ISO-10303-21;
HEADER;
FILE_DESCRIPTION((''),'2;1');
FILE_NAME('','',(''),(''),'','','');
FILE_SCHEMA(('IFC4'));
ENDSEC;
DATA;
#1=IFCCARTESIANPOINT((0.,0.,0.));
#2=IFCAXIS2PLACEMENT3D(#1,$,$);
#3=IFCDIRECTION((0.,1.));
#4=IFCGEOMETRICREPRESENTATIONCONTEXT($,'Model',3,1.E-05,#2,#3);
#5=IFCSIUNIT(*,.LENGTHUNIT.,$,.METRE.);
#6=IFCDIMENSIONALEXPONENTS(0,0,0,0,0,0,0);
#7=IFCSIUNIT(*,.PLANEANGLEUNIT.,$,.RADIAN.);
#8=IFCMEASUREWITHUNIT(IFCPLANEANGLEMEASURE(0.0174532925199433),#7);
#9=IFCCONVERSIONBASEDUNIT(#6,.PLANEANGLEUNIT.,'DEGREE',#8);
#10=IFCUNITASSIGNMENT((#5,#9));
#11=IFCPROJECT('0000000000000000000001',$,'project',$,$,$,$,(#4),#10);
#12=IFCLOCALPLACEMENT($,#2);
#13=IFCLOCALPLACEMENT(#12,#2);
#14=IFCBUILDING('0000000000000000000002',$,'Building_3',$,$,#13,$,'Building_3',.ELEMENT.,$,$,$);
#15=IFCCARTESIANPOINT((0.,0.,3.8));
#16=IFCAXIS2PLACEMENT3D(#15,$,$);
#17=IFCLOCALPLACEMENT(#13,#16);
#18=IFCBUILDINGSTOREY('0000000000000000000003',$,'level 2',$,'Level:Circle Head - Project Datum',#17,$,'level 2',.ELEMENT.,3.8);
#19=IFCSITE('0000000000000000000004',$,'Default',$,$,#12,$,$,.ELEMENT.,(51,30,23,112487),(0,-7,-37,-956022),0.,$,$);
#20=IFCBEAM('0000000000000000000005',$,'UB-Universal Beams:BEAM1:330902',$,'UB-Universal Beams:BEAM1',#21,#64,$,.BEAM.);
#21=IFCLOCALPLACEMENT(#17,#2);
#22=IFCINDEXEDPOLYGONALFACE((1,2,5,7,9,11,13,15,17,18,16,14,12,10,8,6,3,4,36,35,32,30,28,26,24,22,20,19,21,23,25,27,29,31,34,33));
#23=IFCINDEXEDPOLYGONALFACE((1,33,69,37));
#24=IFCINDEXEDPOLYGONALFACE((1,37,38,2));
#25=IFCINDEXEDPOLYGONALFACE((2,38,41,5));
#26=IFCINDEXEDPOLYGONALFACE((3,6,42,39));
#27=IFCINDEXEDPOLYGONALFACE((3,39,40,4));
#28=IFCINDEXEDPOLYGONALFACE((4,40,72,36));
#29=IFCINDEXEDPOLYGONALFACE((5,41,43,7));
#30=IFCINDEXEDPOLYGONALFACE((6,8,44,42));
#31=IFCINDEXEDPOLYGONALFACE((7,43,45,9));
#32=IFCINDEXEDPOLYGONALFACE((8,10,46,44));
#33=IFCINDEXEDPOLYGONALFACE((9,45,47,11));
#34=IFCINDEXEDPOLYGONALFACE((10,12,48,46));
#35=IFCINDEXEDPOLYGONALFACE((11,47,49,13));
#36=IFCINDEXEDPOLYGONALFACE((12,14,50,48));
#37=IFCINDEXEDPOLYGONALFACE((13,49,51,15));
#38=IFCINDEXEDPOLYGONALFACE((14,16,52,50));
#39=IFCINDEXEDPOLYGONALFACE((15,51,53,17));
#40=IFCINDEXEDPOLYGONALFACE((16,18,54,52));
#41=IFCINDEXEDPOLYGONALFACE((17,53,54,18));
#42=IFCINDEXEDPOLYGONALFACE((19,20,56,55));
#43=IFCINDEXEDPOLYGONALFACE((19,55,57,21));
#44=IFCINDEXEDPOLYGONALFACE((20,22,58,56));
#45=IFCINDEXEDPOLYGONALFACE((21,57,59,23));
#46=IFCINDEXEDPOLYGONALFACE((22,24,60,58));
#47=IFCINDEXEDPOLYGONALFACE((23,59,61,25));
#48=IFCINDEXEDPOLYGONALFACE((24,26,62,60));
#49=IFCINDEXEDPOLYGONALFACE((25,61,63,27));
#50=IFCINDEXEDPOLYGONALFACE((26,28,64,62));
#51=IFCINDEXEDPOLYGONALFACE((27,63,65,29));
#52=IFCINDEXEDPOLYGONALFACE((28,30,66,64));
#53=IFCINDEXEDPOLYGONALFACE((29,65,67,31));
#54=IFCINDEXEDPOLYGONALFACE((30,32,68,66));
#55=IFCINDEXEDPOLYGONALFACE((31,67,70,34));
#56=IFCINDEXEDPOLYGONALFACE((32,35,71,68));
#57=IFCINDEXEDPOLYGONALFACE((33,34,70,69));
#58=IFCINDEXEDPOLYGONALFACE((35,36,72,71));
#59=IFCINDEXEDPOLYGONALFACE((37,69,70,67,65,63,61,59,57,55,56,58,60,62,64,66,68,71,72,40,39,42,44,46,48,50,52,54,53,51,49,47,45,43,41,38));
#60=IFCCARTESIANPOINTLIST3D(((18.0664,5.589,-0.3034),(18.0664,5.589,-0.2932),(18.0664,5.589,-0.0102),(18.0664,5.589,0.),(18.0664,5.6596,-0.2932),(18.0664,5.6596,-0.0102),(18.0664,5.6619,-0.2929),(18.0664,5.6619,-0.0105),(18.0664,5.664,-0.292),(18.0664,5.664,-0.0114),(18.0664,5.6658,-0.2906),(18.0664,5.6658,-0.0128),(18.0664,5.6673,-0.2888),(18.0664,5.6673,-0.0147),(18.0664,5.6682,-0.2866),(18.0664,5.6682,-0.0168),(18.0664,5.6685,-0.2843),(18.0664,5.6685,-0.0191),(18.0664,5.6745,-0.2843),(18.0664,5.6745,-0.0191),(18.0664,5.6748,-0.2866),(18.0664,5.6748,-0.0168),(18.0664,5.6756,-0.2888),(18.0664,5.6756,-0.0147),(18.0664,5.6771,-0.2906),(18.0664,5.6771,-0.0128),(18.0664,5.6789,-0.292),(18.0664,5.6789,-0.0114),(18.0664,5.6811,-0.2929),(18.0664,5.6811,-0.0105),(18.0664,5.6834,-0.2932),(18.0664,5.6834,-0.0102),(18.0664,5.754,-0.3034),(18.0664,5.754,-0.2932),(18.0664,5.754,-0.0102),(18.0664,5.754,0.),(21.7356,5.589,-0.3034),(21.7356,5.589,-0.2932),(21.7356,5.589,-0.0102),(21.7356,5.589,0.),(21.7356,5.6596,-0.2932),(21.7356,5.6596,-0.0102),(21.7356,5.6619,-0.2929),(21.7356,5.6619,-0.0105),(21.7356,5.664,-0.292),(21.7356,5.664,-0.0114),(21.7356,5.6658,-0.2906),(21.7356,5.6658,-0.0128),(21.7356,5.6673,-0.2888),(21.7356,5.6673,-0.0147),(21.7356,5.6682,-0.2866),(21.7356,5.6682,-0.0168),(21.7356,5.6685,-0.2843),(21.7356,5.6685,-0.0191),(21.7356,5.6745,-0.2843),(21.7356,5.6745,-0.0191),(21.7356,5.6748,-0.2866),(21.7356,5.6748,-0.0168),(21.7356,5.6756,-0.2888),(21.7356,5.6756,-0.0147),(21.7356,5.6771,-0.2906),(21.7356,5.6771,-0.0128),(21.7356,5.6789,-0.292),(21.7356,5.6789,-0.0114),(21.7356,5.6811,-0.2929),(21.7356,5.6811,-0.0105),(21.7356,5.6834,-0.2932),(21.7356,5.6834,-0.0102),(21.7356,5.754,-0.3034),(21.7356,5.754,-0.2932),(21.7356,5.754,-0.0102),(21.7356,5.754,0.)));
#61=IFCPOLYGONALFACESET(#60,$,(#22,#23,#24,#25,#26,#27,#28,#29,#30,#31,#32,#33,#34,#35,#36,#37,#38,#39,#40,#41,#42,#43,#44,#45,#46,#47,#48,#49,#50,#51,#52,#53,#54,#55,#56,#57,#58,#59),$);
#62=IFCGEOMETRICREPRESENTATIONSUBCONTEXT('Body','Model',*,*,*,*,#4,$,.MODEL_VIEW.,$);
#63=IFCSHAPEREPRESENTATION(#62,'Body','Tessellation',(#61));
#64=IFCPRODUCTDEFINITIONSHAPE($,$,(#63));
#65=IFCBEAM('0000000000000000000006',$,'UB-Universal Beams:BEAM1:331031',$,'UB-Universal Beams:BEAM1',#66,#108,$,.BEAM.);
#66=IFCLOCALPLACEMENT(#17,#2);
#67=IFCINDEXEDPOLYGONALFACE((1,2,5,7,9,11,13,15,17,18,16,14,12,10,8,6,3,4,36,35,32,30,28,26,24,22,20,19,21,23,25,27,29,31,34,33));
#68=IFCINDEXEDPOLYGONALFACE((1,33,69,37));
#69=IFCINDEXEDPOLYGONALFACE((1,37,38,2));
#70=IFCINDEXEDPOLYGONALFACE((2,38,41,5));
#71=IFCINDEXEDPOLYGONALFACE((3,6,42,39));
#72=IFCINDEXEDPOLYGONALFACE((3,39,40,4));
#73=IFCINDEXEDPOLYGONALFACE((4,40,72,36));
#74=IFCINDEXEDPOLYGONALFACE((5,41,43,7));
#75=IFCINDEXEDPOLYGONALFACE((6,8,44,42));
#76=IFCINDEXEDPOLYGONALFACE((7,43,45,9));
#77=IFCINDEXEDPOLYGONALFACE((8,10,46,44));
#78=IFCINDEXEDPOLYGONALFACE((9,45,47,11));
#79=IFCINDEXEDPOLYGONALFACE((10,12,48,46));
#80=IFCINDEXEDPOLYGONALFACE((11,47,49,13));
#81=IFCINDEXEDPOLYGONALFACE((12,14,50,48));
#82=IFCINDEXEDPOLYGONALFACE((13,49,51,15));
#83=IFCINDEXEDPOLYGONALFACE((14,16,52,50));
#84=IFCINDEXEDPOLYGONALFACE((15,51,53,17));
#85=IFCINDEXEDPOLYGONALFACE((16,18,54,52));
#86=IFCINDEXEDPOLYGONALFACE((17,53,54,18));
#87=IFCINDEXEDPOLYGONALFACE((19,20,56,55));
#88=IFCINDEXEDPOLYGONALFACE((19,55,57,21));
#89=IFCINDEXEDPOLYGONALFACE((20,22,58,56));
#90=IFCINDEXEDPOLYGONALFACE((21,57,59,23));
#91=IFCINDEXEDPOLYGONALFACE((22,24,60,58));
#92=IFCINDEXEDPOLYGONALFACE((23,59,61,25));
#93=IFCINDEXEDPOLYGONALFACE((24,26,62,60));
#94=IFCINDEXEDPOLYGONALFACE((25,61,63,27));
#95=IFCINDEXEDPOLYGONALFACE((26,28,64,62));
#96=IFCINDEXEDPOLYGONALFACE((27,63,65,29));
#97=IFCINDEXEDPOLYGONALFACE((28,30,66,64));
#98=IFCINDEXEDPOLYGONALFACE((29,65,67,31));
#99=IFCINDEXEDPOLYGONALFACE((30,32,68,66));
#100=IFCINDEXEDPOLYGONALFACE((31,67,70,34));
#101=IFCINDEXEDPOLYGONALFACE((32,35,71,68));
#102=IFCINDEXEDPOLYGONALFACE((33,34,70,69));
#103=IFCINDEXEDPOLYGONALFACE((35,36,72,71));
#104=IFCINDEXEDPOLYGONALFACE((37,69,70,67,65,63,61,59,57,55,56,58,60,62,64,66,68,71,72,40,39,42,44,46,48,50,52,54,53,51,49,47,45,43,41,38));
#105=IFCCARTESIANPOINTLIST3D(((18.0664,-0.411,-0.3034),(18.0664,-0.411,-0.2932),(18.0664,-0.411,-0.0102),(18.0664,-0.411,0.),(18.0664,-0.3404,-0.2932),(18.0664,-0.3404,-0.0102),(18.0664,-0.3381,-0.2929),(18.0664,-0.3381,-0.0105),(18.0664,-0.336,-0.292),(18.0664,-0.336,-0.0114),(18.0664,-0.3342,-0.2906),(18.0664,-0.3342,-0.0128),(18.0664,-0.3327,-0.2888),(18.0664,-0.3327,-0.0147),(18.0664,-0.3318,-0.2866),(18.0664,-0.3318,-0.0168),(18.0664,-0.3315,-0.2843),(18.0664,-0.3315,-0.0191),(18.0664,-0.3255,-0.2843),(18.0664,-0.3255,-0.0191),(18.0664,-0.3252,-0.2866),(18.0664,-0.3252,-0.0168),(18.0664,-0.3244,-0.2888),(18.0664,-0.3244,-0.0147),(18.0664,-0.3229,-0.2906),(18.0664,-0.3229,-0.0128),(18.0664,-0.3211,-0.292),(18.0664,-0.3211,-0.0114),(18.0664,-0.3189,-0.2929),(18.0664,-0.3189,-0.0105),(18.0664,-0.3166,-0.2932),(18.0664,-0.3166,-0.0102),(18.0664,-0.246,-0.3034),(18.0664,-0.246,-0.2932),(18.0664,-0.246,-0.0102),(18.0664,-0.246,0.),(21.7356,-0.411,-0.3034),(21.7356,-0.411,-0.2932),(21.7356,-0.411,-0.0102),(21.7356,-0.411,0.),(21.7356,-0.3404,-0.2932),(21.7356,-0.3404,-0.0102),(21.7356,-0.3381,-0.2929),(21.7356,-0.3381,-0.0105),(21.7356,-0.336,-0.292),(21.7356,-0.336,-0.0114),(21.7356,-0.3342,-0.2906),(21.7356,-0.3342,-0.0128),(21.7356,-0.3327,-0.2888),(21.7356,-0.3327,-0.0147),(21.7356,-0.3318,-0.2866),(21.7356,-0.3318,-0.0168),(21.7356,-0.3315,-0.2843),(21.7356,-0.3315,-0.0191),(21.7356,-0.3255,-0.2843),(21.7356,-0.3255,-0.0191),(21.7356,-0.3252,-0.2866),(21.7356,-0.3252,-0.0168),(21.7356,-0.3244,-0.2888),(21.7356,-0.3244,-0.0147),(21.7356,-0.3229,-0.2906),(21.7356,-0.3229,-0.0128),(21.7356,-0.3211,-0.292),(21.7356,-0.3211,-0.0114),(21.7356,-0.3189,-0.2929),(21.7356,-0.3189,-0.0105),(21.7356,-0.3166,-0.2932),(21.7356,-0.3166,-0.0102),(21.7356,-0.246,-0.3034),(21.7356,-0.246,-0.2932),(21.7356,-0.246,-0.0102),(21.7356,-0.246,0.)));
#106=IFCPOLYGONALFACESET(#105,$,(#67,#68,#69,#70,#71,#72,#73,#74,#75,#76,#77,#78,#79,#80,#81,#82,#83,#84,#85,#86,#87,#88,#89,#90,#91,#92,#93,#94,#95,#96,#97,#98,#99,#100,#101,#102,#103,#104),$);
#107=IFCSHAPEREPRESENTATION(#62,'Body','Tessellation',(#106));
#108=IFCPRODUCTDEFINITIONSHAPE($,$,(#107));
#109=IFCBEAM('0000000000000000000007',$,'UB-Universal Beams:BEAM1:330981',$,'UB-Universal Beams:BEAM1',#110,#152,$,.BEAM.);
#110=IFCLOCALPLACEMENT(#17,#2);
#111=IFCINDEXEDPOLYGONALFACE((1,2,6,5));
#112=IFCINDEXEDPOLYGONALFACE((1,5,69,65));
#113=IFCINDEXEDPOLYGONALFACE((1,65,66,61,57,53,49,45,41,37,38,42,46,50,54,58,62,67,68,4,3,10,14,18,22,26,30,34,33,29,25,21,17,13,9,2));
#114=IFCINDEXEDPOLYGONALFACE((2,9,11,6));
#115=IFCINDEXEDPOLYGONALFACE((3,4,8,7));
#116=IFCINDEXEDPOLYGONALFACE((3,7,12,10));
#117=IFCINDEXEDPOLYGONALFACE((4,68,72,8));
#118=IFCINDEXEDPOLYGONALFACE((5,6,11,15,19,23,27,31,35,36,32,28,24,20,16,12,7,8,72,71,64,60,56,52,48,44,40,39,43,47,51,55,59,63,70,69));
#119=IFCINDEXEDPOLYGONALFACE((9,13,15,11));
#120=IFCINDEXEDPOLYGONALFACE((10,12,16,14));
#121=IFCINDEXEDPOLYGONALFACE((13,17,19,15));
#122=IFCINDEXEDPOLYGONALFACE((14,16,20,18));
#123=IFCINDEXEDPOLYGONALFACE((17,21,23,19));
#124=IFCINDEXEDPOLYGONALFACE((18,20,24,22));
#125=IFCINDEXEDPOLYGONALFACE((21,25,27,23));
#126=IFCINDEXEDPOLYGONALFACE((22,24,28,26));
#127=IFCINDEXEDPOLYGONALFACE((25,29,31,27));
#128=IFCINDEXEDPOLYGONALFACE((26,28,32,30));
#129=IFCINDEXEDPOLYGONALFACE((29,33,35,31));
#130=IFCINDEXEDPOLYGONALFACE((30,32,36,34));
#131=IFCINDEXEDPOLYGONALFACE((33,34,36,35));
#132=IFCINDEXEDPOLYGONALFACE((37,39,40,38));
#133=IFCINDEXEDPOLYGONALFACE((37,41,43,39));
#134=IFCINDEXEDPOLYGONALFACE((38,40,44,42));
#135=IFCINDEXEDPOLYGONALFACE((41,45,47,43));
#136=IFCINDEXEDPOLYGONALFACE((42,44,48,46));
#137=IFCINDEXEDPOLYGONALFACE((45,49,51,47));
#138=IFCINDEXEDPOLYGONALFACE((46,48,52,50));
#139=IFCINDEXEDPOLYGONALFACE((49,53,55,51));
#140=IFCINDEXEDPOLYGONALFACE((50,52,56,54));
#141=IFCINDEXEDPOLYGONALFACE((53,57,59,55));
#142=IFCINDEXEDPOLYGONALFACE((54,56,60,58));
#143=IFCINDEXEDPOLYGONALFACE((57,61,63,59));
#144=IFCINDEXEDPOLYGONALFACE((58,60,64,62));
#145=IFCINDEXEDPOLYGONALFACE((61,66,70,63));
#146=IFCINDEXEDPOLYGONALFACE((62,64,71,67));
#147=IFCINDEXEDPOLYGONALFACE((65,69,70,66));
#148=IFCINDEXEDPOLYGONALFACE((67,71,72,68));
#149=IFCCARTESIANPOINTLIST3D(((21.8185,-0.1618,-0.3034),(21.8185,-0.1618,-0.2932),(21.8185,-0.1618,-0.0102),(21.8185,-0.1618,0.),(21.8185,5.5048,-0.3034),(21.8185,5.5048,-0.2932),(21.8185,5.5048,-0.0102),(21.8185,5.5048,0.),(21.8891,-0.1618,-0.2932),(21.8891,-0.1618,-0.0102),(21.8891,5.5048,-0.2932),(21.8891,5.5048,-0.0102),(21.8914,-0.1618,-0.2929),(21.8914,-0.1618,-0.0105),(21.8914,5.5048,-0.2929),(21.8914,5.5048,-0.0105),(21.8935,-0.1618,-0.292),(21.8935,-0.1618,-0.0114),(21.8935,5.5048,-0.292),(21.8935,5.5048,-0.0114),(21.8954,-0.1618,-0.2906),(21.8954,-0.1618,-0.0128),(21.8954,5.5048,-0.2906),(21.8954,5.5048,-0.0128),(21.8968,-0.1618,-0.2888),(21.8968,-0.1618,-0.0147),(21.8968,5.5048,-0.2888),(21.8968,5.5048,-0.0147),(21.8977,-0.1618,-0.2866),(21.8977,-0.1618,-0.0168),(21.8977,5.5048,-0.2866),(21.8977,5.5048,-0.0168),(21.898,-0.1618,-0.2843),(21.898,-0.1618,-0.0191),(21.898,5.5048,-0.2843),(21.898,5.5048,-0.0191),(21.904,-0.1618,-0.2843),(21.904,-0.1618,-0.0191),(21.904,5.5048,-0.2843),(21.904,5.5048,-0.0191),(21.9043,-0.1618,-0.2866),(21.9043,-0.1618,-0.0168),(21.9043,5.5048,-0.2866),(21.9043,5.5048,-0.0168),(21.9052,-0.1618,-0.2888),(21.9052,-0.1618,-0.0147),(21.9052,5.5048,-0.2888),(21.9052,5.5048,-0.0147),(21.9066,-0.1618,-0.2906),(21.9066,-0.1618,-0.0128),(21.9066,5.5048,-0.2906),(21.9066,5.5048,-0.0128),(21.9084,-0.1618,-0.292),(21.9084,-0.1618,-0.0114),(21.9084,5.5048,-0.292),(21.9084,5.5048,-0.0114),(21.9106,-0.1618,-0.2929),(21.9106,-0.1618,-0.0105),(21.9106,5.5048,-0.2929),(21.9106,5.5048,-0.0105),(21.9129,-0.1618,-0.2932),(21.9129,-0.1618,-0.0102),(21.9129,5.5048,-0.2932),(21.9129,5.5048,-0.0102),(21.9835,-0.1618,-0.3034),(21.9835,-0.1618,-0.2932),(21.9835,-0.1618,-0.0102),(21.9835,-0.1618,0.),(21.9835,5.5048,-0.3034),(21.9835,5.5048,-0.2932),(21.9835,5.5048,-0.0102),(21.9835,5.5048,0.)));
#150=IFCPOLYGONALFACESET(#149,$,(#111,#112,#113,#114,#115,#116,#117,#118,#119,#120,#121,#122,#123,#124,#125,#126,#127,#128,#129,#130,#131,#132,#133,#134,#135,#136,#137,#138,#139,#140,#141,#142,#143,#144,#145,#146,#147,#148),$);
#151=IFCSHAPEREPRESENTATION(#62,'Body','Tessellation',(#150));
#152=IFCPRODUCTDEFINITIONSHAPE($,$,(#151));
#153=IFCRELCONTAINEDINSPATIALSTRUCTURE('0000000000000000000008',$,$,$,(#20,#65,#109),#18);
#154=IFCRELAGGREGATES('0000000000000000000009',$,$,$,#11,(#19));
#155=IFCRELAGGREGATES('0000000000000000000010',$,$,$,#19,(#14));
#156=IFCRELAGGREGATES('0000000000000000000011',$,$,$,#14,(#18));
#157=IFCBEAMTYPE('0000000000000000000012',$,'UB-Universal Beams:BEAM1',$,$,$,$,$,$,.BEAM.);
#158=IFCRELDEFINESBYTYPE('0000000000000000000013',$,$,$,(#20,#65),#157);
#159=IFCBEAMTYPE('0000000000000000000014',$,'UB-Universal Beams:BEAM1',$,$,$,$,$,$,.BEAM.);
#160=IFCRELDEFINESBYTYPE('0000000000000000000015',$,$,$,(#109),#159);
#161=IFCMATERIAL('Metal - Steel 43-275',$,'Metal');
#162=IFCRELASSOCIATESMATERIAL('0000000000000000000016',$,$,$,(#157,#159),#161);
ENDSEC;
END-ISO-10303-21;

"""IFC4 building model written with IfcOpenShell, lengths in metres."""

from ifc_helpers import new_model, entity, si_unit, converted_unit, direction, frame, frame_2d, origin, place, context, subcontext, project, spatial, polyline, circle_curve, parameter, trimmed, segment, composite_curve, outline, extrude, source, transform, mapped, material, material_profile, profile_set, type_object, type_shapes, element, save


model = new_model("IFC4")

# Units and contexts
model_context = context("Model", 3, precision=1e-05, world=origin(), true_north=direction((0.0, 1.0)))
body_context = subcontext(model_context, "Body", "Model", "MODEL_VIEW")
ifc_project = project(units=[si_unit("LENGTHUNIT", "METRE"), converted_unit("PLANEANGLEUNIT", "DEGREE", entity("IfcPlaneAngleMeasure", 0.0174532925199433), si_unit("PLANEANGLEUNIT", "RADIAN"), dimensions=[0, 0, 0, 0, 0, 0, 0])], contexts=[model_context])

# Site, building, storey
site_placement = place(None, origin())
site = spatial("IfcSite", under=ifc_project, at=site_placement, Name="Default", CompositionType="ELEMENT", RefLatitude=(51, 30, 23, 112487), RefLongitude=(0, -7, -37, -956022), RefElevation=0.0)
building_placement = place(site_placement, origin())
building = spatial("IfcBuilding", under=site, at=building_placement, Name="Building_3", LongName="Building_3", CompositionType="ELEMENT")
storey_placement = place(building_placement, frame((0.0, 0.0, 3.8)))
storey = spatial("IfcBuildingStorey", under=building, at=storey_placement, Name="level 2", ObjectType="Level:Circle Head - Project Datum", LongName="level 2", CompositionType="ELEMENT", Elevation=3.8)

# Beams
ifc_material_1 = material(Name="Metal - Steel 43-275", Category="Metal")
ifc_material_profile = material_profile(ifc_material_1, outline(composite_curve([segment(polyline([(-0.0825, -0.1415), (-0.0825, -0.1517)]), True, "CONTINUOUS"), segment(polyline([(-0.0825, -0.1517), (0.0825, -0.1517)]), True, "CONTINUOUS"), segment(polyline([(0.0825, -0.1517), (0.0825, -0.1415)]), True, "CONTINUOUS"), segment(polyline([(0.0825, -0.1415), (0.0119, -0.1415)]), True, "CONTINUOUS"), segment(trimmed(circle_curve(frame_2d((0.0119, -0.1326), x_axis=(1.0, 0.0)), 0.0089), [parameter(180.0)], [parameter(270.0)], True, "PARAMETER"), False, "CONTINUOUS"), segment(polyline([(0.003, -0.1326), (0.003, 0.1326)]), True, "CONTINUOUS"), segment(trimmed(circle_curve(frame_2d((0.0119, 0.1326), x_axis=(1.0, 0.0)), 0.0089), [parameter(90.0)], [parameter(180.0)], True, "PARAMETER"), False, "CONTINUOUS"), segment(polyline([(0.0119, 0.1415), (0.0825, 0.1415)]), True, "CONTINUOUS"), segment(polyline([(0.0825, 0.1415), (0.0825, 0.1517)]), True, "CONTINUOUS"), segment(polyline([(0.0825, 0.1517), (-0.0825, 0.1517)]), True, "CONTINUOUS"), segment(polyline([(-0.0825, 0.1517), (-0.0825, 0.1415)]), True, "CONTINUOUS"), segment(polyline([(-0.0825, 0.1415), (-0.0119, 0.1415)]), True, "CONTINUOUS"), segment(trimmed(circle_curve(frame_2d((-0.0119, 0.1326), x_axis=(1.0, 0.0)), 0.0089), [parameter(360.0)], [parameter(90.0)], True, "PARAMETER"), False, "CONTINUOUS"), segment(polyline([(-0.003, 0.1326), (-0.003, -0.1326)]), True, "CONTINUOUS"), segment(trimmed(circle_curve(frame_2d((-0.0119, -0.1326), x_axis=(1.0, 0.0)), 0.0089), [parameter(270.0)], [parameter(360.0)], True, "PARAMETER"), False, "CONTINUOUS"), segment(polyline([(-0.0119, -0.1415), (-0.0825, -0.1415)]), True, "CONTINUOUS")], self_intersect=False)), Name="BEAM1")
ifc_profile_set = profile_set([ifc_material_profile], Name="BEAM1")
beam_type_1 = type_object("IfcBeamType", Name="UB-Universal Beams:BEAM1", PredefinedType="BEAM", material=ifc_profile_set)
shared_shape_1 = source(origin(), body_context, "Body", "SweptSolid", [
    extrude(outline(composite_curve([segment(polyline([(-0.0825, -0.1415), (-0.0825, -0.1517)]), True, "CONTINUOUS"), segment(polyline([(-0.0825, -0.1517), (0.0825, -0.1517)]), True, "CONTINUOUS"), segment(polyline([(0.0825, -0.1517), (0.0825, -0.1415)]), True, "CONTINUOUS"), segment(polyline([(0.0825, -0.1415), (0.0119, -0.1415)]), True, "CONTINUOUS"), segment(trimmed(circle_curve(frame_2d((0.0119, -0.1326), x_axis=(0.0, -1.0)), 0.0089), [parameter(270.0)], [parameter(360.0)], True, "PARAMETER"), False, "CONTINUOUS"), segment(polyline([(0.003, -0.1326), (0.003, 0.1326)]), True, "CONTINUOUS"), segment(trimmed(circle_curve(frame_2d((0.0119, 0.1326), x_axis=(-1.0, 0.0)), 0.0089), [parameter(270.0)], [parameter(360.0)], True, "PARAMETER"), False, "CONTINUOUS"), segment(polyline([(0.0119, 0.1415), (0.0825, 0.1415)]), True, "CONTINUOUS"), segment(polyline([(0.0825, 0.1415), (0.0825, 0.1517)]), True, "CONTINUOUS"), segment(polyline([(0.0825, 0.1517), (-0.0825, 0.1517)]), True, "CONTINUOUS"), segment(polyline([(-0.0825, 0.1517), (-0.0825, 0.1415)]), True, "CONTINUOUS"), segment(polyline([(-0.0825, 0.1415), (-0.0119, 0.1415)]), True, "CONTINUOUS"), segment(trimmed(circle_curve(frame_2d((-0.0119, 0.1326), x_axis=(0.0, 1.0)), 0.0089), [parameter(270.0)], [parameter(360.0)], True, "PARAMETER"), False, "CONTINUOUS"), segment(polyline([(-0.003, 0.1326), (-0.003, -0.1326)]), True, "CONTINUOUS"), segment(trimmed(circle_curve(frame_2d((-0.0119, -0.1326), x_axis=(1.0, 0.0)), 0.0089), [parameter(270.0)], [parameter(0.0)], True, "PARAMETER"), False, "CONTINUOUS"), segment(polyline([(-0.0119, -0.1415), (-0.0825, -0.1415)]), True, "CONTINUOUS")], self_intersect=False)), frame((-1.8346, 0.0, 0.0), z_axis=(-1.0, 0.0, 0.0), x_axis=(0.0, -1.0, 0.0)), (0.0, 0.0, -1.0), 3.6692),
])
type_shapes(beam_type_1, [shared_shape_1])
for number, where, name in (
    (1, (19.901, 5.6715, -0.1517), "UB-Universal Beams:BEAM1:330902"),
    (2, (19.901, -0.3285, -0.1517), "UB-Universal Beams:BEAM1:331031"),
):
    element("IfcBeam", number, at=place(storey_placement, frame(where)), inside=storey, type_object=beam_type_1, Name=name, ObjectType="UB-Universal Beams:BEAM1", PredefinedType="BEAM", context=body_context, shape_type="MappedRepresentation", body=[
        mapped(shared_shape_1, transform((0.0, 0.0, 0.0), scale=1.0)),
    ])
beam_type_2 = type_object("IfcBeamType", Name="UB-Universal Beams:BEAM1", PredefinedType="BEAM", material=ifc_profile_set)
shared_shape_2 = source(origin(), body_context, "Body", "SweptSolid", [
    extrude(outline(composite_curve([segment(polyline([(-0.0825, -0.1415), (-0.0825, -0.1517)]), True, "CONTINUOUS"), segment(polyline([(-0.0825, -0.1517), (0.0825, -0.1517)]), True, "CONTINUOUS"), segment(polyline([(0.0825, -0.1517), (0.0825, -0.1415)]), True, "CONTINUOUS"), segment(polyline([(0.0825, -0.1415), (0.0119, -0.1415)]), True, "CONTINUOUS"), segment(trimmed(circle_curve(frame_2d((0.0119, -0.1326), x_axis=(1.0, 0.0)), 0.0089), [parameter(180.0)], [parameter(270.0)], True, "PARAMETER"), False, "CONTINUOUS"), segment(polyline([(0.003, -0.1326), (0.003, 0.1326)]), True, "CONTINUOUS"), segment(trimmed(circle_curve(frame_2d((0.0119, 0.1326), x_axis=(1.0, 0.0)), 0.0089), [parameter(90.0)], [parameter(180.0)], True, "PARAMETER"), False, "CONTINUOUS"), segment(polyline([(0.0119, 0.1415), (0.0825, 0.1415)]), True, "CONTINUOUS"), segment(polyline([(0.0825, 0.1415), (0.0825, 0.1517)]), True, "CONTINUOUS"), segment(polyline([(0.0825, 0.1517), (-0.0825, 0.1517)]), True, "CONTINUOUS"), segment(polyline([(-0.0825, 0.1517), (-0.0825, 0.1415)]), True, "CONTINUOUS"), segment(polyline([(-0.0825, 0.1415), (-0.0119, 0.1415)]), True, "CONTINUOUS"), segment(trimmed(circle_curve(frame_2d((-0.0119, 0.1326), x_axis=(1.0, 0.0)), 0.0089), [parameter(360.0)], [parameter(90.0)], True, "PARAMETER"), False, "CONTINUOUS"), segment(polyline([(-0.003, 0.1326), (-0.003, -0.1326)]), True, "CONTINUOUS"), segment(trimmed(circle_curve(frame_2d((-0.0119, -0.1326), x_axis=(1.0, 0.0)), 0.0089), [parameter(270.0)], [parameter(360.0)], True, "PARAMETER"), False, "CONTINUOUS"), segment(polyline([(-0.0119, -0.1415), (-0.0825, -0.1415)]), True, "CONTINUOUS")], self_intersect=False)), frame((-2.8333, 0.0, 0.0), z_axis=(-1.0, 0.0, 0.0), x_axis=(0.0, -1.0, 0.0)), (0.0, 0.0, -1.0), 5.6666),
])
type_shapes(beam_type_2, [shared_shape_2])
for number, where, z_axis, x_axis, name in (
    (3, (21.901, 2.6715, -0.1517), (0.0, 0.0, 1.0), (0.0, -1.0, 0.0), "UB-Universal Beams:BEAM1:330981"),
):
    element("IfcBeam", number, at=place(storey_placement, frame(where, z_axis=z_axis, x_axis=x_axis)), inside=storey, type_object=beam_type_2, Name=name, ObjectType="UB-Universal Beams:BEAM1", PredefinedType="BEAM", context=body_context, shape_type="MappedRepresentation", body=[
        mapped(shared_shape_2, transform((0.0, 0.0, 0.0), scale=1.0)),
    ])

save(model, "model.ifc")
